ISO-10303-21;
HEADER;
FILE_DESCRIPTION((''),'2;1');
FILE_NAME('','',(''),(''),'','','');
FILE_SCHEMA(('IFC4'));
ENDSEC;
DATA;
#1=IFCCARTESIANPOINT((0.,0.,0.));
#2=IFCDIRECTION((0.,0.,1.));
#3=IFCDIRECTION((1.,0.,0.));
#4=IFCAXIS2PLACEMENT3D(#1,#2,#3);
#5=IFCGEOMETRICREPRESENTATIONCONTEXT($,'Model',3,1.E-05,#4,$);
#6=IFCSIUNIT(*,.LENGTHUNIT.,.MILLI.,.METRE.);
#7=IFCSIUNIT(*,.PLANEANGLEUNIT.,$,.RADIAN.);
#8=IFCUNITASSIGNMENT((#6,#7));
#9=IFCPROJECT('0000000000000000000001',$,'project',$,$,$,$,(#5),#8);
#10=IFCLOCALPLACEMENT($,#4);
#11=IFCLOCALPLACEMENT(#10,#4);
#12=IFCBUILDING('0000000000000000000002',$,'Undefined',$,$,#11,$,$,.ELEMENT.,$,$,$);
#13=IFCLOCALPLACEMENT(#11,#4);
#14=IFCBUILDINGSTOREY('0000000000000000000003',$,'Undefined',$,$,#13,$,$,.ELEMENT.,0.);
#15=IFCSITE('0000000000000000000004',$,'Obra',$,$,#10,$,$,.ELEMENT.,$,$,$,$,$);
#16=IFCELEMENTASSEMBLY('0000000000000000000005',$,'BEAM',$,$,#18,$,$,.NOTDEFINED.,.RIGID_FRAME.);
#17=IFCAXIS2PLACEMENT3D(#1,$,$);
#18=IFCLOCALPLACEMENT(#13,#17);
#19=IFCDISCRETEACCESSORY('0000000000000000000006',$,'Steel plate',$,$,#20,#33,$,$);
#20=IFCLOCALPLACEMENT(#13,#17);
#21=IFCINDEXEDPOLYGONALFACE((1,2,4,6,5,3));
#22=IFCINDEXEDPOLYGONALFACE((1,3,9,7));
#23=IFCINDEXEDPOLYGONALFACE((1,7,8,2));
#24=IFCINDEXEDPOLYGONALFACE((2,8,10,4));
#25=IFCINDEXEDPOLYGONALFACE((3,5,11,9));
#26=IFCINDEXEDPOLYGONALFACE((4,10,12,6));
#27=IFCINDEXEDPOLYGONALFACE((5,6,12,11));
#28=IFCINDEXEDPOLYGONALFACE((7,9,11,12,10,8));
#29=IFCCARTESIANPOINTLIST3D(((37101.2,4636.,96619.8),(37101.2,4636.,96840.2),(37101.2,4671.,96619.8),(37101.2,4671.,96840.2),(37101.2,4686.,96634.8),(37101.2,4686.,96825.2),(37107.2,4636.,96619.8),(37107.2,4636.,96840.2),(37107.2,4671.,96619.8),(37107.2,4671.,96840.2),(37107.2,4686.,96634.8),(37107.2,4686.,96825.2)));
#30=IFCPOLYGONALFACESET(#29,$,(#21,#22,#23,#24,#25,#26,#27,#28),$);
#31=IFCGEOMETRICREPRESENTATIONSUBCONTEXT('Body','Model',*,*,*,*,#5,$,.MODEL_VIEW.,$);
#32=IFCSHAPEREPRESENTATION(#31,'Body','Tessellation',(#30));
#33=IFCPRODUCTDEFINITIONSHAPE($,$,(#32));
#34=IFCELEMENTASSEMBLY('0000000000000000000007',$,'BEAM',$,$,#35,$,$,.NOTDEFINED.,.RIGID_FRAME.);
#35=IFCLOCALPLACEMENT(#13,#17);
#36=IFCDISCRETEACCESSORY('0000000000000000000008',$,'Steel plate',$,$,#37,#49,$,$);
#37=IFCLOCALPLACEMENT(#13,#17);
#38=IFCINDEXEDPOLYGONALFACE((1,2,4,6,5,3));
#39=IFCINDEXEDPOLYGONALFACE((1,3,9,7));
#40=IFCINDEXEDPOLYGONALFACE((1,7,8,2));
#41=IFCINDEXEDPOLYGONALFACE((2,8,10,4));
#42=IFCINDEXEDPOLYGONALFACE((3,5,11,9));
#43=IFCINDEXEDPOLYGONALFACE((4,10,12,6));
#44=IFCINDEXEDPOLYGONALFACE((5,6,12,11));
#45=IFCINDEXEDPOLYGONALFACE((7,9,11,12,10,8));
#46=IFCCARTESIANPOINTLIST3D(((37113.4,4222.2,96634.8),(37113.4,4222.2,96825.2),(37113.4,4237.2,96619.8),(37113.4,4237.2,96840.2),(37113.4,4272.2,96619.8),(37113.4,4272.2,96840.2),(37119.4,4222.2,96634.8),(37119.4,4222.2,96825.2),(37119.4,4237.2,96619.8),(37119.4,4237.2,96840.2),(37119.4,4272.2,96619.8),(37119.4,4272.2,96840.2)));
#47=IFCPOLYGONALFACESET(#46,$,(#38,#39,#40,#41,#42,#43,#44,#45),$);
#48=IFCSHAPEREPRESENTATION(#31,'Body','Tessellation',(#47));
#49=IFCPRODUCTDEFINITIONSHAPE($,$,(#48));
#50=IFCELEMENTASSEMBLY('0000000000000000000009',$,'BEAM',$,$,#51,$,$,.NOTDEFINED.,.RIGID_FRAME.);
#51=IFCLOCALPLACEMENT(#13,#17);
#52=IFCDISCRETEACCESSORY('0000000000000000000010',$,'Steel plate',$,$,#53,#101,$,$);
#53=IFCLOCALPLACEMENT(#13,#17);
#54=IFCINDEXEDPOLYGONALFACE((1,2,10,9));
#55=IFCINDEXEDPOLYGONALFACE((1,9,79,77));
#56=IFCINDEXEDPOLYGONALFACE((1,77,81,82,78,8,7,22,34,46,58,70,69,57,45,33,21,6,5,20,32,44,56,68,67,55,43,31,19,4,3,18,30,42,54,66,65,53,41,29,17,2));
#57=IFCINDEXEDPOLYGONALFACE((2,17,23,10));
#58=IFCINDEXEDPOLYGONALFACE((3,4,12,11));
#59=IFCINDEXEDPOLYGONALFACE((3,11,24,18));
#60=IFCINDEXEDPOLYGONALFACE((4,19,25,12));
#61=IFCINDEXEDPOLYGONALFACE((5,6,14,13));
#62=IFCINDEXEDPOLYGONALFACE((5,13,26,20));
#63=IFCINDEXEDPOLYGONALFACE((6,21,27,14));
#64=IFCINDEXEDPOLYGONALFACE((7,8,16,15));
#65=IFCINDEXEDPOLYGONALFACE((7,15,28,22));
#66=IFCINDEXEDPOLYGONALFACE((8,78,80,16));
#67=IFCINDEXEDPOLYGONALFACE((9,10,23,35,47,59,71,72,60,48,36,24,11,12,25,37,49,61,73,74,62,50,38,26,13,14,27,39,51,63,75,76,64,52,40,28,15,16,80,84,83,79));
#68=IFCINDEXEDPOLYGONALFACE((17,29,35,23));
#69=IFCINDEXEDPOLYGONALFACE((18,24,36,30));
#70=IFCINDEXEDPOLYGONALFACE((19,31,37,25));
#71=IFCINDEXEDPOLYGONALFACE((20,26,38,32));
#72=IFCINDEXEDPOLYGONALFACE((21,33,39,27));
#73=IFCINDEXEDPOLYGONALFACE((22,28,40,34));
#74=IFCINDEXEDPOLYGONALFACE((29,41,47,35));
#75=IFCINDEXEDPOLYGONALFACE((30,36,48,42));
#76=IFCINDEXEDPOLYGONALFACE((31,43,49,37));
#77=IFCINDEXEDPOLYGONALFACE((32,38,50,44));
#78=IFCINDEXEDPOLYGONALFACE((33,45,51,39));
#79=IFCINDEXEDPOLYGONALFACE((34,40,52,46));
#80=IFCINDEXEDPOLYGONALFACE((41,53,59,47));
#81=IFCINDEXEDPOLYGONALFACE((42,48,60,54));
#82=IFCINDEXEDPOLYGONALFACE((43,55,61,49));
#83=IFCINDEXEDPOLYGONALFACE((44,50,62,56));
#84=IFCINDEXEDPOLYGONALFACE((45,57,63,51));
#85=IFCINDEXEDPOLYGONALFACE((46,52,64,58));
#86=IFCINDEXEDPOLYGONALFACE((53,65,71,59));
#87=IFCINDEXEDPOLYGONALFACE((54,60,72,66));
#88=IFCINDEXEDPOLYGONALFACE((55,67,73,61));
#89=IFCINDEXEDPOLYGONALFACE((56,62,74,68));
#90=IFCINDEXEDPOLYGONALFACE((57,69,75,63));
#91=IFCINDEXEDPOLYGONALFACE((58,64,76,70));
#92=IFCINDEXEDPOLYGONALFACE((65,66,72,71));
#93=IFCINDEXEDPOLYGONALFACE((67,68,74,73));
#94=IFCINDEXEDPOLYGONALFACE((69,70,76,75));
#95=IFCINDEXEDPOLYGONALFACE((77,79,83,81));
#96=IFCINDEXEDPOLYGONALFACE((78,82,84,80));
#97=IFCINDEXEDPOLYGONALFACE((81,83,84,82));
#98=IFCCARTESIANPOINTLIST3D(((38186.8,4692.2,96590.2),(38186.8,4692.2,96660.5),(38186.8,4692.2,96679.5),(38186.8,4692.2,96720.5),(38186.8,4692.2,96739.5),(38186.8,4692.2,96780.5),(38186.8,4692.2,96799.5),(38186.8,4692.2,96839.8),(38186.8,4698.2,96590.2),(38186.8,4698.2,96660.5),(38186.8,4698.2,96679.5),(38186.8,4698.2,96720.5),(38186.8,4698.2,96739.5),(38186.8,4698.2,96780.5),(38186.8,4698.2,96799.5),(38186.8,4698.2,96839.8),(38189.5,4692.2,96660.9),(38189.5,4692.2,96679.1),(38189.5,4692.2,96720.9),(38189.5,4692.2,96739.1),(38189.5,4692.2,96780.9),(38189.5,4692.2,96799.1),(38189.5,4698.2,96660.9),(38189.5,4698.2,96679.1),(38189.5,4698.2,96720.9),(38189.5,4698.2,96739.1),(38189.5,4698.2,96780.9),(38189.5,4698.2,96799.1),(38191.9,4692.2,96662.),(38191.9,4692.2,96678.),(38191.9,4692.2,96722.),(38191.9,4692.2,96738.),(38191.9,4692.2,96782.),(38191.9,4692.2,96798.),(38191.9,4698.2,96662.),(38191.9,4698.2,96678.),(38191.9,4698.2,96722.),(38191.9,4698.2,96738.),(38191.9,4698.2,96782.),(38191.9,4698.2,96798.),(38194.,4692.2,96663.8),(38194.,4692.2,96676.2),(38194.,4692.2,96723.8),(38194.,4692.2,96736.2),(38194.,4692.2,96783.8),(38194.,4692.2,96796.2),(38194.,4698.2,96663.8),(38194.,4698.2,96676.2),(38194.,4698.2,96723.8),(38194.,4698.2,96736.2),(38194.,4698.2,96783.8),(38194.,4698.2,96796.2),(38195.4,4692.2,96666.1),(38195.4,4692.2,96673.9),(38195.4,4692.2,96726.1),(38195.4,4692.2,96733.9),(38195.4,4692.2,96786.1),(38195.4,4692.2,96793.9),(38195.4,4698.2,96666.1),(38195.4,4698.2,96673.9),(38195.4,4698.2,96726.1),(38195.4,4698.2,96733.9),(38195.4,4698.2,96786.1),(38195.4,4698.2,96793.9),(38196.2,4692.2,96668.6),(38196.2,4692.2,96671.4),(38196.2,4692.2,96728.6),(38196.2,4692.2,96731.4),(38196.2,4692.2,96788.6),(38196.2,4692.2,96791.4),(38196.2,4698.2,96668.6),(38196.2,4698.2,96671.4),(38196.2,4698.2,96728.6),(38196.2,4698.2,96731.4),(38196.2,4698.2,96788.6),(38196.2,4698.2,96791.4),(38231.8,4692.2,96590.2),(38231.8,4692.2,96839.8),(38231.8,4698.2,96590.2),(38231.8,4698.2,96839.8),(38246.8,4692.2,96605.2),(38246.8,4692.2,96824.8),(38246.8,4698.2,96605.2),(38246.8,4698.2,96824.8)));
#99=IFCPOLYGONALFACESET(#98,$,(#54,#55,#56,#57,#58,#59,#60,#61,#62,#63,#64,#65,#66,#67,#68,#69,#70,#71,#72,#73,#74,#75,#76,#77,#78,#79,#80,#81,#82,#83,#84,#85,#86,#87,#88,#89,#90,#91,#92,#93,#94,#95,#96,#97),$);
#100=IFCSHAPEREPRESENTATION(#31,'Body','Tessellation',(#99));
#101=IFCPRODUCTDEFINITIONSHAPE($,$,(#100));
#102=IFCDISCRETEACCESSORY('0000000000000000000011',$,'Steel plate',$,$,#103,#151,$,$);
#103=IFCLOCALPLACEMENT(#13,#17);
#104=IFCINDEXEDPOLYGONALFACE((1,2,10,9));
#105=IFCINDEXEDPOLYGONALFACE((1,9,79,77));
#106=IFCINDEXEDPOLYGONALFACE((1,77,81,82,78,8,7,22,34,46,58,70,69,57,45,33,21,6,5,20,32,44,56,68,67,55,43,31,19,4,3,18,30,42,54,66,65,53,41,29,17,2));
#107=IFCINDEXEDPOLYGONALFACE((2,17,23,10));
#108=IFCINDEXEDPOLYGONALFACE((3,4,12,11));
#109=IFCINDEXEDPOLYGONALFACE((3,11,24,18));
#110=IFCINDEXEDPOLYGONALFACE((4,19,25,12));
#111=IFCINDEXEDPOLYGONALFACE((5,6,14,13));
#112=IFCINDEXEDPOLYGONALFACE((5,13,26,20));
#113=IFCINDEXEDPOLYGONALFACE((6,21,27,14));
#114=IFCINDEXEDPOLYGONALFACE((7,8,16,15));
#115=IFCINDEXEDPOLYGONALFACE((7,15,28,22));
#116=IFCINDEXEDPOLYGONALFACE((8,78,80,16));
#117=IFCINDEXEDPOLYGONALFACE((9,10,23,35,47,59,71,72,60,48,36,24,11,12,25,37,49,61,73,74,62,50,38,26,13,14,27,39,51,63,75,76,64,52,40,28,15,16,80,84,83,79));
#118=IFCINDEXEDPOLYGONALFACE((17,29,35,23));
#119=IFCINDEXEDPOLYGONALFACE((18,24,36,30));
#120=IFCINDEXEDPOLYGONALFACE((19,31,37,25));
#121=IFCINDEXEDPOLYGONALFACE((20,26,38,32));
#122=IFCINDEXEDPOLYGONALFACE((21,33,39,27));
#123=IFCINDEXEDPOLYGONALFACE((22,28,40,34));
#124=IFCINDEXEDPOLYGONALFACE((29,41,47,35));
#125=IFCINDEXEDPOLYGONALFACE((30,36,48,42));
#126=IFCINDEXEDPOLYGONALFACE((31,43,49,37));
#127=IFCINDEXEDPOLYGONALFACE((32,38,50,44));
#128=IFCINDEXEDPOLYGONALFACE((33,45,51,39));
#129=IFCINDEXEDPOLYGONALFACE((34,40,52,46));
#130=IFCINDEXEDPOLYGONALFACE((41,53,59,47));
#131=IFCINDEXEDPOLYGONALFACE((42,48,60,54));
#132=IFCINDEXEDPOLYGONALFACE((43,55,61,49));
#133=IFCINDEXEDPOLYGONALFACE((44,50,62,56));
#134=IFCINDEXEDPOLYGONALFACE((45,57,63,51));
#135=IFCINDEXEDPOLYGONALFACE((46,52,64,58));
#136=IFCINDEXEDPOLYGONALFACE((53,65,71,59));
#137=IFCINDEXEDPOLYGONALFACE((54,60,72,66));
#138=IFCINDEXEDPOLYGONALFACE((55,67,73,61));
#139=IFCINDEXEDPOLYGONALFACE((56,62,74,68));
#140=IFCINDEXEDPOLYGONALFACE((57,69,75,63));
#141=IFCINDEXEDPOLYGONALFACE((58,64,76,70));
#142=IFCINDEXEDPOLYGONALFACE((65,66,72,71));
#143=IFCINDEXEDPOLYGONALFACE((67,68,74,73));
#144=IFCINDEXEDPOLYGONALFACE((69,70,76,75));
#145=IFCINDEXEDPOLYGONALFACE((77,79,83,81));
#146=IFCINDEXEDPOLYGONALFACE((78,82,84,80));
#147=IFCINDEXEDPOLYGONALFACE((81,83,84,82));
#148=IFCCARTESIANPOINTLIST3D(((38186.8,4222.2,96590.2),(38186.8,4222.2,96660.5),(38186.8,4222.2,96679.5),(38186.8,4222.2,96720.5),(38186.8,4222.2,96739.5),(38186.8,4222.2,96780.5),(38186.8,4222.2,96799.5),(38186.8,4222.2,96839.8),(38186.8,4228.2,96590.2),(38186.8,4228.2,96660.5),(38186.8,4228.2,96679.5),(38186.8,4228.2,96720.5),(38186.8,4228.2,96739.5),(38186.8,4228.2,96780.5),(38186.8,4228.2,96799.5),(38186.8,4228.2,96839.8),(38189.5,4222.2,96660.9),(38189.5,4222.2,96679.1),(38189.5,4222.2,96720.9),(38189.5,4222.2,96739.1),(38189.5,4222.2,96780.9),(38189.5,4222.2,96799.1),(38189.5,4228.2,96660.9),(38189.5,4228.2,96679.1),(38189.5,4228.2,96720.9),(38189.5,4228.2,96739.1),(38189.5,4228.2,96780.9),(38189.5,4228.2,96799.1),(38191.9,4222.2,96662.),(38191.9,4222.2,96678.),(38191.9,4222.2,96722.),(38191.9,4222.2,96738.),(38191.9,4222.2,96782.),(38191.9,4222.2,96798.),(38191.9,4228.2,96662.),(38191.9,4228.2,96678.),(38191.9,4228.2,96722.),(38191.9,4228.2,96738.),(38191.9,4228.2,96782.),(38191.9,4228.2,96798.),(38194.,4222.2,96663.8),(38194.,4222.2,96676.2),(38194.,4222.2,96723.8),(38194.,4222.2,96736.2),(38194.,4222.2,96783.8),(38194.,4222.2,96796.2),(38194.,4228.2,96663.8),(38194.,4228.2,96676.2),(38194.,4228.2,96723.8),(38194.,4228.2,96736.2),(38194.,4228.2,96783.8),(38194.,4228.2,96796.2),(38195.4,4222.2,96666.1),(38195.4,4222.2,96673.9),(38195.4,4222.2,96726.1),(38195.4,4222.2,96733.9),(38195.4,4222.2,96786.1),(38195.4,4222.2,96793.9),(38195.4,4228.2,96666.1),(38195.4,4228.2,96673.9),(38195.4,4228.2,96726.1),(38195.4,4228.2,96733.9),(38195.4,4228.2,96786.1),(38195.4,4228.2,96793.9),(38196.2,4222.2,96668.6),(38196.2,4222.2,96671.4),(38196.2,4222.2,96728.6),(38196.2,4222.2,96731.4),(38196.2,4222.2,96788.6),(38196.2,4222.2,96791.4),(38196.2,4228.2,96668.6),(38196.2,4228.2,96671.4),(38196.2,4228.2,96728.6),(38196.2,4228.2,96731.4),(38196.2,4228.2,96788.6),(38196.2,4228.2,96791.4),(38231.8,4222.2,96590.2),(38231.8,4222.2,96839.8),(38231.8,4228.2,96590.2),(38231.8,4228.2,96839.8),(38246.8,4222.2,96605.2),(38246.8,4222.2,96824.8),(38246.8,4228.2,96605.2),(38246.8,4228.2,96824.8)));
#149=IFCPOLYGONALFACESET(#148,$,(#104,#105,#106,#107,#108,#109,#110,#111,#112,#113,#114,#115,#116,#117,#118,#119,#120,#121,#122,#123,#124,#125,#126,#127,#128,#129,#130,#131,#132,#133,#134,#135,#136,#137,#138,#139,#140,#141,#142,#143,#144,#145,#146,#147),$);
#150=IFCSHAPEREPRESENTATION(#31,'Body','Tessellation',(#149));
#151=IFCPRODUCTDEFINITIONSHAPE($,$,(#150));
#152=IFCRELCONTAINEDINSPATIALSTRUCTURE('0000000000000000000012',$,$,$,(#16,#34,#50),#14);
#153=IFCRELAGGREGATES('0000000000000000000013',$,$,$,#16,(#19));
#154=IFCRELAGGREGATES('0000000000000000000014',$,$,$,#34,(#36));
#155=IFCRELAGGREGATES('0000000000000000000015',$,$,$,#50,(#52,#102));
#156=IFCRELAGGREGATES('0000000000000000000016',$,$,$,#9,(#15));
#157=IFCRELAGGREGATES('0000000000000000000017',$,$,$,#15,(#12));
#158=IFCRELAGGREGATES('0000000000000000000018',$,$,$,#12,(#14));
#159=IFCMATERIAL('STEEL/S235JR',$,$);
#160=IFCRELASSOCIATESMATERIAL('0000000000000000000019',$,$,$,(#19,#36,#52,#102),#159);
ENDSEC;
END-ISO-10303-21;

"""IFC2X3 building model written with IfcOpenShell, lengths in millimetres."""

from ifc_helpers import new_model, si_unit, frame, origin_with_axes, origin_2d_with_axis, place, context, subcontext, project, spatial, polyline, circle, outline, extrude, source, transform, mapped, material, element, aggregate, save


model = new_model("IFC2X3")

# Units and contexts
model_context = context("Model", 3, precision=1e-05, world=origin_with_axes())
body_context = subcontext(model_context, "Body", "Model", "MODEL_VIEW")
ifc_project = project(units=[si_unit("LENGTHUNIT", "METRE", prefix="MILLI"), si_unit("PLANEANGLEUNIT", "RADIAN")], contexts=[model_context])

# Site, building, storey
site_placement = place(None, origin_with_axes())
site = spatial("IfcSite", under=ifc_project, at=site_placement, Name="Obra", CompositionType="ELEMENT")
building_placement = place(site_placement, origin_with_axes())
building = spatial("IfcBuilding", under=site, at=building_placement, Name="Undefined", CompositionType="ELEMENT")
storey_placement = place(building_placement, origin_with_axes())
storey = spatial("IfcBuildingStorey", under=building, at=storey_placement, Name="Undefined", CompositionType="ELEMENT", Elevation=0.0)

# Element assemblies, discrete accessories
assembly_1_placement = place(storey_placement, origin_with_axes())
assembly_1 = element("IfcElementAssembly", 1, at=assembly_1_placement, inside=storey, Name="BEAM", AssemblyPlace="NOTDEFINED", PredefinedType="RIGID_FRAME")
ifc_material = material(Name="STEEL/S235JR")
discrete_accessory_1_placement = place(assembly_1_placement, frame((37104.2, 4636.0, 96619.8), z_axis=(1.0, 0.0, 0.0), x_axis=(0.0, 1.0, 0.0)))
discrete_accessory_1 = element("IfcDiscreteAccessory", 2, at=discrete_accessory_1_placement, material=ifc_material, Name="Steel plate", context=body_context, shape_type="SweptSolid", body=[
    extrude(outline(polyline([(0.0, 0.0), (35.0, 0.0), (50.0, 15.0), (50.0, 205.4), (35.0, 220.4), (0.0, 220.4), (0.0, 0.0)])), frame((0.0, 0.0, -3.0), z_axis=(0.0, 0.0, 1.0), x_axis=(1.0, 0.0, 0.0)), (0.0, 0.0, 1.0), 6.0),
])
aggregate(assembly_1, [discrete_accessory_1])
assembly_2_placement = place(storey_placement, origin_with_axes())
assembly_2 = element("IfcElementAssembly", 3, at=assembly_2_placement, inside=storey, Name="BEAM", AssemblyPlace="NOTDEFINED", PredefinedType="RIGID_FRAME")
discrete_accessory_2_placement = place(assembly_2_placement, frame((37116.4, 4272.2, 96619.8), z_axis=(-1.0, 0.0, 0.0), x_axis=(0.0, -1.0, 0.0)))
discrete_accessory_2 = element("IfcDiscreteAccessory", 4, at=discrete_accessory_2_placement, material=ifc_material, Name="Steel plate", context=body_context, shape_type="SweptSolid", body=[
    extrude(outline(polyline([(0.0, 0.0), (35.0, 0.0), (50.0, 15.0), (50.0, 205.4), (35.0, 220.4), (0.0, 220.4), (0.0, 0.0)])), frame((0.0, 0.0, -3.0), z_axis=(0.0, 0.0, 1.0), x_axis=(1.0, 0.0, 0.0)), (0.0, 0.0, 1.0), 6.0),
])
aggregate(assembly_2, [discrete_accessory_2])

# Element assembly, discrete accessories, openings
assembly_3_placement = place(storey_placement, origin_with_axes())
assembly_3 = element("IfcElementAssembly", 5, at=assembly_3_placement, inside=storey, Name="BEAM", AssemblyPlace="NOTDEFINED", PredefinedType="RIGID_FRAME")
discrete_accessory_3_placement = place(assembly_3_placement, frame((38186.8, 4695.2, 96590.2), z_axis=(0.0, -1.0, 0.0), x_axis=(1.0, 0.0, 0.0)))
discrete_accessory_3 = element("IfcDiscreteAccessory", 6, at=discrete_accessory_3_placement, material=ifc_material, Name="Steel plate", context=body_context, shape_type="SweptSolid", body=[
    extrude(outline(polyline([(0.0, 0.0), (45.0, 0.0), (60.0, 15.0), (60.0, 234.6), (45.0, 249.6), (0.0, 249.6), (0.0, 0.0)])), frame((0.0, 0.0, -3.0), z_axis=(0.0, 0.0, 1.0), x_axis=(1.0, 0.0, 0.0)), (0.0, 0.0, 1.0), 6.0),
])
shared_shape = source(origin_with_axes(), body_context, "Body", "SweptSolid", [
    extrude(circle(Radius=9.5, at=origin_2d_with_axis()), frame((0.0, -9.2, 0.0), z_axis=(0.0, 1.0, 0.0), x_axis=(1.0, 0.0, 0.0)), (0.0, 0.0, 1.0), 6.2),
])
opening_1_placement = place(assembly_3_placement, frame((38236.8, 4689.1, 96850.0), z_axis=(-1.0, 0.0, 0.0), x_axis=(0.0, 0.0, -1.0)))
element("IfcOpeningElement", 7, at=opening_1_placement, cuts=discrete_accessory_3, ObjectType="Opening", context=body_context, shape_type="MappedRepresentation", body=[
    mapped(shared_shape, transform((60.0, 0.0, 50.0))),
    mapped(shared_shape, transform((120.0, 0.0, 50.0))),
    mapped(shared_shape, transform((180.0, 0.0, 50.0))),
])
discrete_accessory_4_placement = place(assembly_3_placement, frame((38186.8, 4225.2, 96590.2), z_axis=(0.0, -1.0, 0.0), x_axis=(1.0, 0.0, 0.0)))
discrete_accessory_4 = element("IfcDiscreteAccessory", 8, at=discrete_accessory_4_placement, material=ifc_material, Name="Steel plate", context=body_context, shape_type="SweptSolid", body=[
    extrude(outline(polyline([(0.0, 0.0), (45.0, 0.0), (60.0, 15.0), (60.0, 234.6), (45.0, 249.6), (0.0, 249.6), (0.0, 0.0)])), frame((0.0, 0.0, -3.0), z_axis=(0.0, 0.0, 1.0), x_axis=(1.0, 0.0, 0.0)), (0.0, 0.0, 1.0), 6.0),
])
opening_2_placement = place(assembly_3_placement, frame((38236.8, 4219.1, 96850.0), z_axis=(-1.0, 0.0, 0.0), x_axis=(0.0, 0.0, -1.0)))
element("IfcOpeningElement", 9, at=opening_2_placement, cuts=discrete_accessory_4, ObjectType="Opening", context=body_context, shape_type="MappedRepresentation", body=[
    mapped(shared_shape, transform((60.0, 0.0, 50.0))),
    mapped(shared_shape, transform((120.0, 0.0, 50.0))),
    mapped(shared_shape, transform((180.0, 0.0, 50.0))),
])
aggregate(assembly_3, [discrete_accessory_3, discrete_accessory_4])

save(model, "model.ifc")
